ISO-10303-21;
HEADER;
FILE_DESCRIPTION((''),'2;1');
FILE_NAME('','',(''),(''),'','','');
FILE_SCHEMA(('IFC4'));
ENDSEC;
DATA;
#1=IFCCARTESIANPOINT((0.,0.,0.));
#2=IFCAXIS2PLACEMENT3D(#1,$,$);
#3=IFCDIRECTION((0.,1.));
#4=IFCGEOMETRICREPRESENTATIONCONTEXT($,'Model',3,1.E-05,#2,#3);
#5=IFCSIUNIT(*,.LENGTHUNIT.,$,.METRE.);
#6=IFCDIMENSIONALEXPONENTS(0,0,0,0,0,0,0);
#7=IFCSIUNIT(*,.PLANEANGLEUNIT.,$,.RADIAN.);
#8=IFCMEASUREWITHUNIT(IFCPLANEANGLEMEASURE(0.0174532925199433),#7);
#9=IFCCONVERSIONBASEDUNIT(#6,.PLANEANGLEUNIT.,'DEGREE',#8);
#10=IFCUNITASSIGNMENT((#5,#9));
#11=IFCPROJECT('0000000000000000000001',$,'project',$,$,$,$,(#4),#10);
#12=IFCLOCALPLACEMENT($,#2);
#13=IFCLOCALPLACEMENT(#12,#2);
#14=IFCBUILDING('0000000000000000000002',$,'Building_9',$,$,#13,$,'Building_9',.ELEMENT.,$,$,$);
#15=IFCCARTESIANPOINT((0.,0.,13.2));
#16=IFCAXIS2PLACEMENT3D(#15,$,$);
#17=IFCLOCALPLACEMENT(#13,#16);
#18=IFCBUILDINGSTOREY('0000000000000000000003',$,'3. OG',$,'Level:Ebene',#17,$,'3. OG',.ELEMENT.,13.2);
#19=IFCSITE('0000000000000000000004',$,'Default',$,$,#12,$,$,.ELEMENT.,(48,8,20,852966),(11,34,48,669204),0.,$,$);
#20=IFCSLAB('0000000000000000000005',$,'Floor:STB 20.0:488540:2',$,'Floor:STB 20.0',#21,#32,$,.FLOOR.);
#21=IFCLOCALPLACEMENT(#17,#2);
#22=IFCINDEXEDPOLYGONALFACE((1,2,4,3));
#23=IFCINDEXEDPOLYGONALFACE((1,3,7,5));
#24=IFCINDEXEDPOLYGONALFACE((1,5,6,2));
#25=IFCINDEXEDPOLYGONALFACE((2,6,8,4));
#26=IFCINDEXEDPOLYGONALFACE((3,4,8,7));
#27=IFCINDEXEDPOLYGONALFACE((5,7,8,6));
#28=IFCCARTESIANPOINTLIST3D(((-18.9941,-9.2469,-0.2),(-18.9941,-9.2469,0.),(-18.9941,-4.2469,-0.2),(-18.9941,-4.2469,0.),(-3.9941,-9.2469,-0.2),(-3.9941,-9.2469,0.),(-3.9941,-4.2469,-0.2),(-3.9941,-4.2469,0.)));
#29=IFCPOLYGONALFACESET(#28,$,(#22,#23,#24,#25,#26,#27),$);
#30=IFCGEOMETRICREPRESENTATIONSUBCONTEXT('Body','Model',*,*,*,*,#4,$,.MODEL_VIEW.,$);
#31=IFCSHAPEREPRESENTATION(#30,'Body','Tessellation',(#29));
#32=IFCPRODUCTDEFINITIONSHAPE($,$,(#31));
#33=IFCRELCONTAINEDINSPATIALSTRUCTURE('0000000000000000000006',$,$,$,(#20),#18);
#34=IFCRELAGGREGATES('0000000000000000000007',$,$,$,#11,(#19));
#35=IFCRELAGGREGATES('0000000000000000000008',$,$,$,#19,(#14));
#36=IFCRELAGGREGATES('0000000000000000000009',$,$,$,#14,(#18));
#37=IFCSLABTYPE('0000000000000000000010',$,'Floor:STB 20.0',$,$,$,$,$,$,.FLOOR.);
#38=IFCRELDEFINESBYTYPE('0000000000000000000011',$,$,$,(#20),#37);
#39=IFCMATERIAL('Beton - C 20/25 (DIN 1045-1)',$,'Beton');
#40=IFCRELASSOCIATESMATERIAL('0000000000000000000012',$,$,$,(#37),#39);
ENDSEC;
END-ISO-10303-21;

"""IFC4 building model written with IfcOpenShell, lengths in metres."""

from ifc_helpers import new_model, entity, si_unit, converted_unit, direction, frame, frame_2d, origin, place, context, subcontext, project, spatial, rectangle, extrude, material, type_object, element, save


model = new_model("IFC4")

# Units and contexts
model_context = context("Model", 3, precision=1e-05, world=origin(), true_north=direction((0.0, 1.0)))
body_context = subcontext(model_context, "Body", "Model", "MODEL_VIEW")
ifc_project = project(units=[si_unit("LENGTHUNIT", "METRE"), converted_unit("PLANEANGLEUNIT", "DEGREE", entity("IfcPlaneAngleMeasure", 0.0174532925199433), si_unit("PLANEANGLEUNIT", "RADIAN"), dimensions=[0, 0, 0, 0, 0, 0, 0])], contexts=[model_context])

# Site, building, storey
site_placement = place(None, origin())
site = spatial("IfcSite", under=ifc_project, at=site_placement, Name="Default", CompositionType="ELEMENT", RefLatitude=(48, 8, 20, 852966), RefLongitude=(11, 34, 48, 669204), RefElevation=0.0)
building_placement = place(site_placement, origin())
building = spatial("IfcBuilding", under=site, at=building_placement, Name="Building_9", LongName="Building_9", CompositionType="ELEMENT")
storey_placement = place(building_placement, frame((0.0, 0.0, 13.2)))
storey = spatial("IfcBuildingStorey", under=building, at=storey_placement, Name="3. OG", ObjectType="Level:Ebene", LongName="3. OG", CompositionType="ELEMENT", Elevation=13.2)

# Slab
ifc_material = material(Name="Beton - C 20/25 (DIN 1045-1)", Category="Beton")
slab_type = type_object("IfcSlabType", Name="Floor:STB 20.0", PredefinedType="FLOOR", material=ifc_material)
slab_1_placement = place(storey_placement, frame((-18.9941, -9.2469, -0.2)))
element("IfcSlab", 1, at=slab_1_placement, inside=storey, type_object=slab_type, Name="Floor:STB 20.0:488540:2", ObjectType="Floor:STB 20.0", PredefinedType="FLOOR", context=body_context, shape_type="SweptSolid", body=[
    extrude(rectangle(XDim=15.0, YDim=5.0, at=frame_2d((0.0, -17.0), x_axis=(-1.0, 0.0))), frame((7.5, 19.5, 0.2), z_axis=(0.0, 0.0, -1.0), x_axis=(-1.0, 0.0, 0.0)), (0.0, 0.0, 1.0), 0.2),
])

save(model, "model.ifc")
